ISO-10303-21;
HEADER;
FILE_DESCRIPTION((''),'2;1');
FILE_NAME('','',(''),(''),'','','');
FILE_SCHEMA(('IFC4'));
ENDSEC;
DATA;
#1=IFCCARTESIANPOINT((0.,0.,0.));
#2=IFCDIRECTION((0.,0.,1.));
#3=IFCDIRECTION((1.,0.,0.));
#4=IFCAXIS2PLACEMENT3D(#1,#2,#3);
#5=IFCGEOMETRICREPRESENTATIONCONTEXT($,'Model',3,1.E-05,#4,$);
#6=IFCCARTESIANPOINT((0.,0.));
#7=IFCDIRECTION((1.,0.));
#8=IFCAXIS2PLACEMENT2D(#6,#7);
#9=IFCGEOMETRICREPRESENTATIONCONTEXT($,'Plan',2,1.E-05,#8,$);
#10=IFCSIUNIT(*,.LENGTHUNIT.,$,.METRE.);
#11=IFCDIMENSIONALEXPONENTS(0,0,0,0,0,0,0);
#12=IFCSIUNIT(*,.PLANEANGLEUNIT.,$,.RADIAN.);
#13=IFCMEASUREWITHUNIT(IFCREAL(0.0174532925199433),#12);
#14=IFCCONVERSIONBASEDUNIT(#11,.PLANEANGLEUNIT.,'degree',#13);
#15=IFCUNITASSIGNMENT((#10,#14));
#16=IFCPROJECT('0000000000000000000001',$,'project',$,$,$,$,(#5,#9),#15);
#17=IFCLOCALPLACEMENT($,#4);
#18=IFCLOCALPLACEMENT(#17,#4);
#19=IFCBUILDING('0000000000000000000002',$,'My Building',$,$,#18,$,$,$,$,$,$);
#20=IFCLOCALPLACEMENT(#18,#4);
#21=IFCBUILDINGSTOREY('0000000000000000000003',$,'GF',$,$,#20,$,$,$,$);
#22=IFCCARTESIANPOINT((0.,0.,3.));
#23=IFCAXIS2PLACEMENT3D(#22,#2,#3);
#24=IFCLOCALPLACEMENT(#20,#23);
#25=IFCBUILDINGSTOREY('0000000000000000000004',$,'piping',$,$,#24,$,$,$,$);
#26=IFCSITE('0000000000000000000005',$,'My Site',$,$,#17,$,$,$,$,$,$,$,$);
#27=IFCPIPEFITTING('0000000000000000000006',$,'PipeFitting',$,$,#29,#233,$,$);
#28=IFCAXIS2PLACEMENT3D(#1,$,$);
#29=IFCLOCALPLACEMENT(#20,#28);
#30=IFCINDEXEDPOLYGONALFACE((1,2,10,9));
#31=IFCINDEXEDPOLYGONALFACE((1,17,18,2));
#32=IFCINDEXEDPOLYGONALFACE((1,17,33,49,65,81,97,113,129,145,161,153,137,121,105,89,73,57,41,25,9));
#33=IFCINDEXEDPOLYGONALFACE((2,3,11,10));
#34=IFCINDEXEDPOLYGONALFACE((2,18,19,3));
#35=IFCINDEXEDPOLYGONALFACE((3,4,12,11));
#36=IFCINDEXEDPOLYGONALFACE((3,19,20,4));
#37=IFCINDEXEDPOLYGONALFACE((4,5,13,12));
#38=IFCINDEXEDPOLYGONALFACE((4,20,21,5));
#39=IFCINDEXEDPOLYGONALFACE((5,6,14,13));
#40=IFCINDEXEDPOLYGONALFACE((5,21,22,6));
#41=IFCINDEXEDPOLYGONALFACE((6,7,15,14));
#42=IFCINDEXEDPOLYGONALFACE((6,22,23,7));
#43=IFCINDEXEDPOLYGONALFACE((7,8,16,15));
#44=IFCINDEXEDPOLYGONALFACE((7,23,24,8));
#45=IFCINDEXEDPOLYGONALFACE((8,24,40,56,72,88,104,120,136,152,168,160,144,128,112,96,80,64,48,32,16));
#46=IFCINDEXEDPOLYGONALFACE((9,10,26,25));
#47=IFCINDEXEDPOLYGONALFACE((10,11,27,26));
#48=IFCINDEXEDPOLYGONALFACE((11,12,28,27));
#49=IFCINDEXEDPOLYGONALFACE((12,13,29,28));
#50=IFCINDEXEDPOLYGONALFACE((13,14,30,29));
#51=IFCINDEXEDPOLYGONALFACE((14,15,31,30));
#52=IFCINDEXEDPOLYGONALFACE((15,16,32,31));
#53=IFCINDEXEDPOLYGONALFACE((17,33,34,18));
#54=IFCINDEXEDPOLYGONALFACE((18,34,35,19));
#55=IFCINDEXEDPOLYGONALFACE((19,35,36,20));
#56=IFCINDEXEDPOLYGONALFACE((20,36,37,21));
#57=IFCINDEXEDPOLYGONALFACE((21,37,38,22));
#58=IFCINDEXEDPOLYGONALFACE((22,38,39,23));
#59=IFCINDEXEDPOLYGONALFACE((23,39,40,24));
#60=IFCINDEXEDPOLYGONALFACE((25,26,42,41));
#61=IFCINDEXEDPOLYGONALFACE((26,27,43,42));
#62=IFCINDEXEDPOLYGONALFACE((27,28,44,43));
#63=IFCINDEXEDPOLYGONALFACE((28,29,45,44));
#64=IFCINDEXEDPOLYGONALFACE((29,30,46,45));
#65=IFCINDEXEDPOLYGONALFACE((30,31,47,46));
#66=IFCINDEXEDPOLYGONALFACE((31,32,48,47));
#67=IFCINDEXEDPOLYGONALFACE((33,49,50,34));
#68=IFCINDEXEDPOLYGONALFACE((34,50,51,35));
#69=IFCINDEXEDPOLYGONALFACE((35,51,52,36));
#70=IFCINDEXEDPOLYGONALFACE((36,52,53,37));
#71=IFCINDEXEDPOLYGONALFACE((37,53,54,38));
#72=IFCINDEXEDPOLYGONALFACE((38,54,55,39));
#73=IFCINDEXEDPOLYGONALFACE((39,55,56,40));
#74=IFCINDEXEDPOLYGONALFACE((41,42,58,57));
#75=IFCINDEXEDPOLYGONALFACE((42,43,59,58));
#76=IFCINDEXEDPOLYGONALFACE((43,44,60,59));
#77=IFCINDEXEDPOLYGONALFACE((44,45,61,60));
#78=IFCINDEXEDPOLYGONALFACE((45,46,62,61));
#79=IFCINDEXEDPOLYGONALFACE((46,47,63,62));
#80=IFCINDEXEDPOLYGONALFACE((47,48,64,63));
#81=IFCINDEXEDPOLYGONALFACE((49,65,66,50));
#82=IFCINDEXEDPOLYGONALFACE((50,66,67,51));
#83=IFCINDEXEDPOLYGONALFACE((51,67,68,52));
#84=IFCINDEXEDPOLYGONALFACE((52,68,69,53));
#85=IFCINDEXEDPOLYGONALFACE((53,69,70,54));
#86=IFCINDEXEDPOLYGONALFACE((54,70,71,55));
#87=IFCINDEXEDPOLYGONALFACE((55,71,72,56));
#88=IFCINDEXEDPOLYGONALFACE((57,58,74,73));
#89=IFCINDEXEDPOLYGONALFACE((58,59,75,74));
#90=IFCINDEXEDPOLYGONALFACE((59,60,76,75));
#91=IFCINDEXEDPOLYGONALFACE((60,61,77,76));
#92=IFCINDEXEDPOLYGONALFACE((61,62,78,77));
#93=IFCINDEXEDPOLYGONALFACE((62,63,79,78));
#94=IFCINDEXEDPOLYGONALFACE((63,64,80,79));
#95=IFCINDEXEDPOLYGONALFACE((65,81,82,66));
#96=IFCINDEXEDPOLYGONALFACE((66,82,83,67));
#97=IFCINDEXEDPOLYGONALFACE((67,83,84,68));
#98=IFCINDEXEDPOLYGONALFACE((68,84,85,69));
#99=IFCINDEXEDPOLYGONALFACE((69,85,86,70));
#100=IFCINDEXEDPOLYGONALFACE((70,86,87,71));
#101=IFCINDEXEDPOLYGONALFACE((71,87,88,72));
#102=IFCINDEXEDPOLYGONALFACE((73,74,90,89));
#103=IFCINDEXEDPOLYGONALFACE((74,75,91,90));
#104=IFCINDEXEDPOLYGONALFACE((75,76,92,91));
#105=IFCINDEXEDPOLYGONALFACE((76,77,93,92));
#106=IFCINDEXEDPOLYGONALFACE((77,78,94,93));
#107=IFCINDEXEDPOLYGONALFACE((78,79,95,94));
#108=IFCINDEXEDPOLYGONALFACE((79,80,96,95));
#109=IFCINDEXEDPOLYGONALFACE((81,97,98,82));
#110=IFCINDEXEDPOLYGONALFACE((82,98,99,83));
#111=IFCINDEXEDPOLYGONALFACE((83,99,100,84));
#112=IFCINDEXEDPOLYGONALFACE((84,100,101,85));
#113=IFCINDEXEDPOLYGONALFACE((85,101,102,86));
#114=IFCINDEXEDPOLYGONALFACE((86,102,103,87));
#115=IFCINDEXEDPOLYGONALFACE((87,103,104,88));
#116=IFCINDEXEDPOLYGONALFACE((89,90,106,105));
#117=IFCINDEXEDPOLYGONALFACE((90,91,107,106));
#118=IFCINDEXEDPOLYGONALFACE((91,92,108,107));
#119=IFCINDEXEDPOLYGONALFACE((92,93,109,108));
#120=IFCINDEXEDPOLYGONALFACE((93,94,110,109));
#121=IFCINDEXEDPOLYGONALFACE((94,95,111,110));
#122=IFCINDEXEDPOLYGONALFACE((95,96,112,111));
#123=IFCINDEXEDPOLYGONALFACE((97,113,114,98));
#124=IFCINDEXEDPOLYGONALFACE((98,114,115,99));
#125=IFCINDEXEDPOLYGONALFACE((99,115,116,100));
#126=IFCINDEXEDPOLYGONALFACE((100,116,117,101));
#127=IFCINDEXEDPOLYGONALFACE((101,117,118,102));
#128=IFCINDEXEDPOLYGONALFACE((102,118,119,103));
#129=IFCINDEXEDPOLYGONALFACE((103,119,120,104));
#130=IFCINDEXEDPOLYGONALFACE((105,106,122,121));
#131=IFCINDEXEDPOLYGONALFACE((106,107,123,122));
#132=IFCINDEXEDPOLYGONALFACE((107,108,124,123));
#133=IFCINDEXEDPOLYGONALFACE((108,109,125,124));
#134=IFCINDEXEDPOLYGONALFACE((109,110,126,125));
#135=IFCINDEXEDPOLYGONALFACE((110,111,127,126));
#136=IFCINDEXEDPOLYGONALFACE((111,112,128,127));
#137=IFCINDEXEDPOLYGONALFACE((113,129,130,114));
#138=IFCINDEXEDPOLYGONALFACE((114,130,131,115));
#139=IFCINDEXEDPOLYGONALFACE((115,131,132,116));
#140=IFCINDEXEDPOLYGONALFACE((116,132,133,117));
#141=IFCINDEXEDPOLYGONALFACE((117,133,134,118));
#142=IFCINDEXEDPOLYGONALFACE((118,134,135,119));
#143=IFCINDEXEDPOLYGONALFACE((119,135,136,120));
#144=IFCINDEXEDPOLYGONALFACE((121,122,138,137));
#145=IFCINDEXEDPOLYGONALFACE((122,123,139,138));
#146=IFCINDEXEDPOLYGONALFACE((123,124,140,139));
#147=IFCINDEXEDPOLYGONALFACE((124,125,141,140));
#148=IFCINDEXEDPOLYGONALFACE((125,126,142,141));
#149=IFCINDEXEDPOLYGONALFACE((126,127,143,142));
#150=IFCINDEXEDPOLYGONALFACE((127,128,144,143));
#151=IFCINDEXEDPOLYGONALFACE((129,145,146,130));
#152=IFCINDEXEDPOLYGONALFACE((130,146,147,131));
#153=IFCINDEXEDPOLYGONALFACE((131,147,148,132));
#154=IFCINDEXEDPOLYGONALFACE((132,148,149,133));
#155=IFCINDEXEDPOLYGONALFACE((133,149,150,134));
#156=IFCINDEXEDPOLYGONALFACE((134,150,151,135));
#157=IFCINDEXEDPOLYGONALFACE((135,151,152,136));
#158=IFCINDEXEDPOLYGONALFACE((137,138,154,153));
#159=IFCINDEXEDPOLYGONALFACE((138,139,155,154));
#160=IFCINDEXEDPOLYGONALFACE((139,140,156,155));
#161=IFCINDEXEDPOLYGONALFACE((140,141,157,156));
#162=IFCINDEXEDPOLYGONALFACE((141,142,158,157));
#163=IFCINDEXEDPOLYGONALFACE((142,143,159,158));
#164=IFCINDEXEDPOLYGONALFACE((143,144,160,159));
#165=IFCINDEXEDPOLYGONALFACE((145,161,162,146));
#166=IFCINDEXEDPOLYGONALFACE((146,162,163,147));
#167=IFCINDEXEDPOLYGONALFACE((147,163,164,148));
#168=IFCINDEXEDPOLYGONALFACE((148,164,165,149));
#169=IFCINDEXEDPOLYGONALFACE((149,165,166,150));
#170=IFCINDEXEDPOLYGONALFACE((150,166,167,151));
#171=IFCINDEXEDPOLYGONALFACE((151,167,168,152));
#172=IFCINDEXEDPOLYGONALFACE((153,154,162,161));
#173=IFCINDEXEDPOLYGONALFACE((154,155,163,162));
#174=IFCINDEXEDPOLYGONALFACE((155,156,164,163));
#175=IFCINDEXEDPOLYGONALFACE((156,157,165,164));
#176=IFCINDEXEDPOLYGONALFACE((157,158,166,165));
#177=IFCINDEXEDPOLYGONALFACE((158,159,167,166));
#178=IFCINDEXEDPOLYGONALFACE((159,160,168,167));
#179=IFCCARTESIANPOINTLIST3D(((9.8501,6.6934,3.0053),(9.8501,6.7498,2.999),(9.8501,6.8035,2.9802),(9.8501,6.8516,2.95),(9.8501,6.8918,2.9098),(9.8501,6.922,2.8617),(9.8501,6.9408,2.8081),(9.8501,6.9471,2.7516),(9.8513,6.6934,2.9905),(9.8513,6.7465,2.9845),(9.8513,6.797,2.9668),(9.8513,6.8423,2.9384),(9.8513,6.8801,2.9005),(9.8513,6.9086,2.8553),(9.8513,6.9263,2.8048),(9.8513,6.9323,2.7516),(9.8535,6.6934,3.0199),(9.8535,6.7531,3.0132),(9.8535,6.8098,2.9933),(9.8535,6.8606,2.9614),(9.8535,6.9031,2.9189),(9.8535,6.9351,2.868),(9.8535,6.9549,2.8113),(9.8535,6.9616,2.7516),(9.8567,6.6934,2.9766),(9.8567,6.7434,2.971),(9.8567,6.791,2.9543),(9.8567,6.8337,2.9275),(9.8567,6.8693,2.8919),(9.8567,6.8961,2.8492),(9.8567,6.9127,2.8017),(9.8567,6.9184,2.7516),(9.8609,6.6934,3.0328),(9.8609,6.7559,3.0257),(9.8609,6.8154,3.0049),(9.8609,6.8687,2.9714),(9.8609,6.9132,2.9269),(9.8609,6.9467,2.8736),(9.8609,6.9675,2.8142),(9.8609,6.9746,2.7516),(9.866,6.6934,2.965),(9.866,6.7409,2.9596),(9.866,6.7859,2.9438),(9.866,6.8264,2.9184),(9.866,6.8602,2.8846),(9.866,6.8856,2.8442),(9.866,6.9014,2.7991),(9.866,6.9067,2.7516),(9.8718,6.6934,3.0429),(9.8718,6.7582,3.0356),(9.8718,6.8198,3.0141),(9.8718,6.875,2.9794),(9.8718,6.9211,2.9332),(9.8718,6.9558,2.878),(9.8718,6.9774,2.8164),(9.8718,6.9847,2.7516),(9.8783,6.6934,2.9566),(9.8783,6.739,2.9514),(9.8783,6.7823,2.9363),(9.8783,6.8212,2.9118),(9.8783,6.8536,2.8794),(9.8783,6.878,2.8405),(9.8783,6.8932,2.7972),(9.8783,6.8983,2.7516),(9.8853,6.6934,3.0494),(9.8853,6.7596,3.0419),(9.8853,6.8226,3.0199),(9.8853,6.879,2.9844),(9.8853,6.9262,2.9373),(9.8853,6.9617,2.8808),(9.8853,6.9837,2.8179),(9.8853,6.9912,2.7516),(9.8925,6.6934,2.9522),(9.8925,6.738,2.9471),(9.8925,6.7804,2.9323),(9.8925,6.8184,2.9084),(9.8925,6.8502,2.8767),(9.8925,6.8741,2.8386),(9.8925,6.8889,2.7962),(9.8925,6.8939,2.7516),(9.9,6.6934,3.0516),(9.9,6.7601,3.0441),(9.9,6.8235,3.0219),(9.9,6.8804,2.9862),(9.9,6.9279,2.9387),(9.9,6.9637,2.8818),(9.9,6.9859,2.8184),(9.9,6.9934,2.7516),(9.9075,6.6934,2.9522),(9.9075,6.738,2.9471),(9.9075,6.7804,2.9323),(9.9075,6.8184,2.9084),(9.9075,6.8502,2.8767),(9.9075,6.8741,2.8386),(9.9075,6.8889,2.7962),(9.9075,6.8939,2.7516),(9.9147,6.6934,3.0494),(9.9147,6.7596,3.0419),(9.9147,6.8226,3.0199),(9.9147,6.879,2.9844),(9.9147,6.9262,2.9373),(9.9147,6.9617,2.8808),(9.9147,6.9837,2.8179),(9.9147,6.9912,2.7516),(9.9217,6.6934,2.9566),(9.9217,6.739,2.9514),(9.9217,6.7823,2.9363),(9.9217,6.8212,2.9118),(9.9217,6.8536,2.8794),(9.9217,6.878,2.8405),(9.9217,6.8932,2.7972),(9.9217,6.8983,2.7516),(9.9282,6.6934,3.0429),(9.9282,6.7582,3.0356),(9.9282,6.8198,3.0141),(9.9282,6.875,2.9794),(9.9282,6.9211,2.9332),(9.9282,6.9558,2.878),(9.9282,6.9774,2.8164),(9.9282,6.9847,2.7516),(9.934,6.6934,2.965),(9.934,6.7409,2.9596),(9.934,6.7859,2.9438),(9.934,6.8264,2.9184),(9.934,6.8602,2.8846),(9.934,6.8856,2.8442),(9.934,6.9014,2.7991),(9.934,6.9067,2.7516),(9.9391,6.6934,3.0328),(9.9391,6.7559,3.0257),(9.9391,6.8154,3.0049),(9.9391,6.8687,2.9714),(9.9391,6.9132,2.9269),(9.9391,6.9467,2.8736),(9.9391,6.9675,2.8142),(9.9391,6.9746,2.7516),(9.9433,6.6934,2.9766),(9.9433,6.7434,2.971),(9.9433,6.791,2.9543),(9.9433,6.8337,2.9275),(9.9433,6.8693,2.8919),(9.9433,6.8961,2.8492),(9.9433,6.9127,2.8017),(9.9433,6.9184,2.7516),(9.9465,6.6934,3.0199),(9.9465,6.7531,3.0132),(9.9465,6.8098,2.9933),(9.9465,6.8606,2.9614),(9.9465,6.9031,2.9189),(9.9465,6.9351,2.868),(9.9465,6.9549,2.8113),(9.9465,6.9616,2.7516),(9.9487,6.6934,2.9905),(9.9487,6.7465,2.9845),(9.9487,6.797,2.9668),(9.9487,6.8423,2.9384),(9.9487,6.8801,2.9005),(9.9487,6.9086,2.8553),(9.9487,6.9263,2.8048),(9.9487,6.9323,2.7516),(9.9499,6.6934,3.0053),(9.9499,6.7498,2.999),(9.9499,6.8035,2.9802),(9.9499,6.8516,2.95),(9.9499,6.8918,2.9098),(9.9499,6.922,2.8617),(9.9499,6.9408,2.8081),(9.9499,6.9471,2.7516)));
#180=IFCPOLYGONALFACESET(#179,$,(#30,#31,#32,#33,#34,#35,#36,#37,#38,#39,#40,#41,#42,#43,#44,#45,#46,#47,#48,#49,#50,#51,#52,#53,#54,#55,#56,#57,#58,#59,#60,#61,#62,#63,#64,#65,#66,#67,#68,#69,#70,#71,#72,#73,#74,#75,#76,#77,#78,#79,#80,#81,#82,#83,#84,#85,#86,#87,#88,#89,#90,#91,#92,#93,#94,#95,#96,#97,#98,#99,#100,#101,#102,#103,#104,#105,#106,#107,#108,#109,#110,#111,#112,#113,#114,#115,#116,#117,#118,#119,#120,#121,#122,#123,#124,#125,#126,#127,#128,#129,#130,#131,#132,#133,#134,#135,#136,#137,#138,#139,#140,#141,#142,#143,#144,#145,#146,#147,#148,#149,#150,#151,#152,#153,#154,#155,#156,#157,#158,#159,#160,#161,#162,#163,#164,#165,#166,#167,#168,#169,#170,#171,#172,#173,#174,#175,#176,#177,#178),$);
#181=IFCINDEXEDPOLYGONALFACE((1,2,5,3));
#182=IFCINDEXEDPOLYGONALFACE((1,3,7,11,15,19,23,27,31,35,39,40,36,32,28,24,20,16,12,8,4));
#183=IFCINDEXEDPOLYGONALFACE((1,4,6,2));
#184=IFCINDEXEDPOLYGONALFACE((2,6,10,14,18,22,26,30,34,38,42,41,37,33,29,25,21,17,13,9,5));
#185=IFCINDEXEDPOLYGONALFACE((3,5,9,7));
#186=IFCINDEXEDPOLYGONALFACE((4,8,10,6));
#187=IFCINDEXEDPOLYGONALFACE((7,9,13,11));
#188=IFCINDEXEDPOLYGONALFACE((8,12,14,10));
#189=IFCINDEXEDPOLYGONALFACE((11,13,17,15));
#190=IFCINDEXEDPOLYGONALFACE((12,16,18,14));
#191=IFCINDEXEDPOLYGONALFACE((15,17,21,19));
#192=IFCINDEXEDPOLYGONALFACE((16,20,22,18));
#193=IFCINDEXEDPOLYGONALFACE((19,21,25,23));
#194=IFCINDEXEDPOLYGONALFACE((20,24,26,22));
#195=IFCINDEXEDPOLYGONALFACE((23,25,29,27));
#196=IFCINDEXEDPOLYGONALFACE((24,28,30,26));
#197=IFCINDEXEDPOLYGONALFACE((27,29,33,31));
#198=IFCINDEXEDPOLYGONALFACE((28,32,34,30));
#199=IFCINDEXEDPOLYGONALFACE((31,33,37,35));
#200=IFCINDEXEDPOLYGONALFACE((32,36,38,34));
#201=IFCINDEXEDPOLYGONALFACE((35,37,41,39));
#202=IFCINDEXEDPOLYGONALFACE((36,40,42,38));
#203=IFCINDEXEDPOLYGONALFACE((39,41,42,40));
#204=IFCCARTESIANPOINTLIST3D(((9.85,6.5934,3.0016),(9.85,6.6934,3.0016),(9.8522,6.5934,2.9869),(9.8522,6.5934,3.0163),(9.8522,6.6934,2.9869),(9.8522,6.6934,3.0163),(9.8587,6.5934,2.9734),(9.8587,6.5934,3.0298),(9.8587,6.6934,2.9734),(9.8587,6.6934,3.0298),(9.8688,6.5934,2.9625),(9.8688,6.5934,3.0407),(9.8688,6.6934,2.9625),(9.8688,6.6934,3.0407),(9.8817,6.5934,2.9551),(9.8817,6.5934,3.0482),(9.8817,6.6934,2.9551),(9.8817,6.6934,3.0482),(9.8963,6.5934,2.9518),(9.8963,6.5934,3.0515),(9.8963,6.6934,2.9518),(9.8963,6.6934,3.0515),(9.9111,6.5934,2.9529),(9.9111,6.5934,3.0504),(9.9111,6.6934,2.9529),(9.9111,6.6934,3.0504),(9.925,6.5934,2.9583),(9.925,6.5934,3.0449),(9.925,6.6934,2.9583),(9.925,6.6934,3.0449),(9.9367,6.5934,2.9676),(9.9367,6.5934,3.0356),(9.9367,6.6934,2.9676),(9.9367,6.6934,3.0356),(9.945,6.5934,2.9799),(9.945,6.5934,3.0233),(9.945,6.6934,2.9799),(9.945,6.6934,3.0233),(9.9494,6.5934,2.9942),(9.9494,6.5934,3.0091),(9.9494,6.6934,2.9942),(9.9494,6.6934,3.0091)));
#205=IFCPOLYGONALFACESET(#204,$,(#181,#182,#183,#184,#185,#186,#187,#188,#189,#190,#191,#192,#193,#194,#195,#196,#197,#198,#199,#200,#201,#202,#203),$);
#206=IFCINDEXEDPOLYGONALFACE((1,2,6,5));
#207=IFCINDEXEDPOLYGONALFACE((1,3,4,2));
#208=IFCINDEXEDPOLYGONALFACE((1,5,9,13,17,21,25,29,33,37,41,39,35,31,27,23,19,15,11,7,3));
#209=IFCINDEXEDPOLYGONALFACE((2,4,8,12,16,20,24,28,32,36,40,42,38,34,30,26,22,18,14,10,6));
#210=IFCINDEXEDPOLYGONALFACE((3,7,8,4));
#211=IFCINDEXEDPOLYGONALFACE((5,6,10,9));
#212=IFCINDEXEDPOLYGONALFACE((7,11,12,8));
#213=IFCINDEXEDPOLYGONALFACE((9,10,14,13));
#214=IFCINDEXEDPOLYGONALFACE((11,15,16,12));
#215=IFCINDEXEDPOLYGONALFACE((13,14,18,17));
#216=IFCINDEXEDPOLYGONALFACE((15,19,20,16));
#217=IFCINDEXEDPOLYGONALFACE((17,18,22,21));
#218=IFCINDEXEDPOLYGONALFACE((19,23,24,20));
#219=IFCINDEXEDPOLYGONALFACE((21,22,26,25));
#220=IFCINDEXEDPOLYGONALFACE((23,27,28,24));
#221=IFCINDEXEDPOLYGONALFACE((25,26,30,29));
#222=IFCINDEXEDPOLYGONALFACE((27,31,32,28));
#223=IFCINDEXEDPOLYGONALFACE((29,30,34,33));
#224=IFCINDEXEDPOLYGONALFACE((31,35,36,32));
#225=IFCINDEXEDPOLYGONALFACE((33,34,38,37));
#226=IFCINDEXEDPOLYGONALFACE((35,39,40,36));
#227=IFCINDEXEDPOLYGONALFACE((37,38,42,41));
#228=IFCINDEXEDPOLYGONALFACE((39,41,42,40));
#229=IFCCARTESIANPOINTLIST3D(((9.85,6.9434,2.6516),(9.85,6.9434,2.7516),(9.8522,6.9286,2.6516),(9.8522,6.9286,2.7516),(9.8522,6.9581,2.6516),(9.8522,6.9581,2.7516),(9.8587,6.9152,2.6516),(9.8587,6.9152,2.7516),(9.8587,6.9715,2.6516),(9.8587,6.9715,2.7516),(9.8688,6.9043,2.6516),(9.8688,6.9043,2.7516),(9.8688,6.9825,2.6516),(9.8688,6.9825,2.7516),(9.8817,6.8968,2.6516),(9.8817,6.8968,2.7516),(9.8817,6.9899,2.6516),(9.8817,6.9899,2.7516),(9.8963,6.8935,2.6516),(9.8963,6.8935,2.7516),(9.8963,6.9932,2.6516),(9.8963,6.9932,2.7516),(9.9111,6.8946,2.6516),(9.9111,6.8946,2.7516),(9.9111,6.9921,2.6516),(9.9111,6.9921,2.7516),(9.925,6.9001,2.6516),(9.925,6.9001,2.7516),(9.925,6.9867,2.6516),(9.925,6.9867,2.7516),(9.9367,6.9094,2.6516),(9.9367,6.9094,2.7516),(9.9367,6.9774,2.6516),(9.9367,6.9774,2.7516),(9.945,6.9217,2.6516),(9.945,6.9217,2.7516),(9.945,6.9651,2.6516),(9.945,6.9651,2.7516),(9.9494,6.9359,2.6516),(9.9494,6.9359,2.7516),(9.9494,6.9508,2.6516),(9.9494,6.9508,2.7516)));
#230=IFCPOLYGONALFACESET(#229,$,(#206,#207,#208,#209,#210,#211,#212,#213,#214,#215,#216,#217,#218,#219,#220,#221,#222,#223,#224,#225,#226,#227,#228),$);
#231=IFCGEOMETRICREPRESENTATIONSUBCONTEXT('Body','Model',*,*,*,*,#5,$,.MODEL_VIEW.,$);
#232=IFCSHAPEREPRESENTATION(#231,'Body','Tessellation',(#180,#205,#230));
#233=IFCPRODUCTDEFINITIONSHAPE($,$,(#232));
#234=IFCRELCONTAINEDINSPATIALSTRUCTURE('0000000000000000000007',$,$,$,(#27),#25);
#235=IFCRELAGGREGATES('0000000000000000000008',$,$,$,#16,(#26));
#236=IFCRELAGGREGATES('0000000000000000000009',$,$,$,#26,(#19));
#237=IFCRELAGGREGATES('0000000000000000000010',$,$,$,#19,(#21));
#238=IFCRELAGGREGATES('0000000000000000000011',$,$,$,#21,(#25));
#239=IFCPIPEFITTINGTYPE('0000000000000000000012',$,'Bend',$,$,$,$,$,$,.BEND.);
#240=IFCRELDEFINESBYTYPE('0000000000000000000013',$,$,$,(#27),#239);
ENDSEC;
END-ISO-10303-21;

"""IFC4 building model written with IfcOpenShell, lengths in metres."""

from ifc_helpers import new_model, entity, si_unit, converted_unit, frame, origin_with_axes, origin_2d_with_axis, place, context, subcontext, project, spatial, circle, extrude, source, transform, mapped, type_object, type_shapes, element, save


model = new_model("IFC4")

# Units and contexts
model_context = context("Model", 3, precision=1e-05, world=origin_with_axes())
plan_context = context("Plan", 2, precision=1e-05, world=origin_2d_with_axis())
body_context = subcontext(model_context, "Body", "Model", "MODEL_VIEW")
ifc_project = project(units=[si_unit("LENGTHUNIT", "METRE"), converted_unit("PLANEANGLEUNIT", "degree", entity("IfcReal", 0.0174532925199433), si_unit("PLANEANGLEUNIT", "RADIAN"), dimensions=[0, 0, 0, 0, 0, 0, 0])], contexts=[model_context, plan_context])

# Site, building, storeys
site_placement = place(None, origin_with_axes())
site = spatial("IfcSite", under=ifc_project, at=site_placement, Name="My Site")
building_placement = place(site_placement, origin_with_axes())
building = spatial("IfcBuilding", under=site, at=building_placement, Name="My Building")
storey_1_placement = place(building_placement, origin_with_axes())
storey_1 = spatial("IfcBuildingStorey", under=building, at=storey_1_placement, Name="GF")
storey_2_placement = place(storey_1_placement, frame((0.0, 0.0, 3.0), z_axis=(0.0, 0.0, 1.0), x_axis=(1.0, 0.0, 0.0)))
storey_2 = spatial("IfcBuildingStorey", under=storey_1, at=storey_2_placement, Name="piping")

# Pipe fitting
pipe_fitting_type = type_object("IfcPipeFittingType", Name="Bend", PredefinedType="BEND")
shared_shape = source(origin_with_axes(), body_context, "Body", "SolidModel", [
    entity("IfcSweptDiskSolid", entity("IfcIndexedPolyCurve", entity("IfcCartesianPointList3D", [[0.0, 0.0, -0.1], [0.0, 0.0732, -0.2768], [0.0, 0.25, -0.35]]), [entity("IfcArcIndex", [1, 2, 3])]), 0.05),
    extrude(circle(Radius=0.05), origin_with_axes(), (0.0, 0.0, -1.0), 0.1),
    extrude(circle(Radius=0.05), frame((0.0, 0.25, -0.35), z_axis=(0.0, 1.0, 0.0), x_axis=(1.0, 0.0, 0.0)), (0.0, 0.0, 1.0), 0.1),
])
type_shapes(pipe_fitting_type, [shared_shape])
for number, where, z_axis, x_axis, name in (
    (1, (9.9, 6.5934, 0.0016), (0.0, -1.0, 0.0), (-1.0, 0.0, 0.0), "PipeFitting"),
):
    element("IfcPipeFitting", number, at=place(storey_2_placement, frame(where, z_axis=z_axis, x_axis=x_axis)), inside=storey_2, type_object=pipe_fitting_type, Name=name, context=body_context, shape_type="MappedRepresentation", body=[
        mapped(shared_shape, transform((0.0, 0.0, 0.0), x_axis=(1.0, 0.0, 0.0), y_axis=(0.0, 1.0, 0.0), z_axis=(0.0, 0.0, 1.0), scale=1.0)),
    ])

save(model, "model.ifc")
